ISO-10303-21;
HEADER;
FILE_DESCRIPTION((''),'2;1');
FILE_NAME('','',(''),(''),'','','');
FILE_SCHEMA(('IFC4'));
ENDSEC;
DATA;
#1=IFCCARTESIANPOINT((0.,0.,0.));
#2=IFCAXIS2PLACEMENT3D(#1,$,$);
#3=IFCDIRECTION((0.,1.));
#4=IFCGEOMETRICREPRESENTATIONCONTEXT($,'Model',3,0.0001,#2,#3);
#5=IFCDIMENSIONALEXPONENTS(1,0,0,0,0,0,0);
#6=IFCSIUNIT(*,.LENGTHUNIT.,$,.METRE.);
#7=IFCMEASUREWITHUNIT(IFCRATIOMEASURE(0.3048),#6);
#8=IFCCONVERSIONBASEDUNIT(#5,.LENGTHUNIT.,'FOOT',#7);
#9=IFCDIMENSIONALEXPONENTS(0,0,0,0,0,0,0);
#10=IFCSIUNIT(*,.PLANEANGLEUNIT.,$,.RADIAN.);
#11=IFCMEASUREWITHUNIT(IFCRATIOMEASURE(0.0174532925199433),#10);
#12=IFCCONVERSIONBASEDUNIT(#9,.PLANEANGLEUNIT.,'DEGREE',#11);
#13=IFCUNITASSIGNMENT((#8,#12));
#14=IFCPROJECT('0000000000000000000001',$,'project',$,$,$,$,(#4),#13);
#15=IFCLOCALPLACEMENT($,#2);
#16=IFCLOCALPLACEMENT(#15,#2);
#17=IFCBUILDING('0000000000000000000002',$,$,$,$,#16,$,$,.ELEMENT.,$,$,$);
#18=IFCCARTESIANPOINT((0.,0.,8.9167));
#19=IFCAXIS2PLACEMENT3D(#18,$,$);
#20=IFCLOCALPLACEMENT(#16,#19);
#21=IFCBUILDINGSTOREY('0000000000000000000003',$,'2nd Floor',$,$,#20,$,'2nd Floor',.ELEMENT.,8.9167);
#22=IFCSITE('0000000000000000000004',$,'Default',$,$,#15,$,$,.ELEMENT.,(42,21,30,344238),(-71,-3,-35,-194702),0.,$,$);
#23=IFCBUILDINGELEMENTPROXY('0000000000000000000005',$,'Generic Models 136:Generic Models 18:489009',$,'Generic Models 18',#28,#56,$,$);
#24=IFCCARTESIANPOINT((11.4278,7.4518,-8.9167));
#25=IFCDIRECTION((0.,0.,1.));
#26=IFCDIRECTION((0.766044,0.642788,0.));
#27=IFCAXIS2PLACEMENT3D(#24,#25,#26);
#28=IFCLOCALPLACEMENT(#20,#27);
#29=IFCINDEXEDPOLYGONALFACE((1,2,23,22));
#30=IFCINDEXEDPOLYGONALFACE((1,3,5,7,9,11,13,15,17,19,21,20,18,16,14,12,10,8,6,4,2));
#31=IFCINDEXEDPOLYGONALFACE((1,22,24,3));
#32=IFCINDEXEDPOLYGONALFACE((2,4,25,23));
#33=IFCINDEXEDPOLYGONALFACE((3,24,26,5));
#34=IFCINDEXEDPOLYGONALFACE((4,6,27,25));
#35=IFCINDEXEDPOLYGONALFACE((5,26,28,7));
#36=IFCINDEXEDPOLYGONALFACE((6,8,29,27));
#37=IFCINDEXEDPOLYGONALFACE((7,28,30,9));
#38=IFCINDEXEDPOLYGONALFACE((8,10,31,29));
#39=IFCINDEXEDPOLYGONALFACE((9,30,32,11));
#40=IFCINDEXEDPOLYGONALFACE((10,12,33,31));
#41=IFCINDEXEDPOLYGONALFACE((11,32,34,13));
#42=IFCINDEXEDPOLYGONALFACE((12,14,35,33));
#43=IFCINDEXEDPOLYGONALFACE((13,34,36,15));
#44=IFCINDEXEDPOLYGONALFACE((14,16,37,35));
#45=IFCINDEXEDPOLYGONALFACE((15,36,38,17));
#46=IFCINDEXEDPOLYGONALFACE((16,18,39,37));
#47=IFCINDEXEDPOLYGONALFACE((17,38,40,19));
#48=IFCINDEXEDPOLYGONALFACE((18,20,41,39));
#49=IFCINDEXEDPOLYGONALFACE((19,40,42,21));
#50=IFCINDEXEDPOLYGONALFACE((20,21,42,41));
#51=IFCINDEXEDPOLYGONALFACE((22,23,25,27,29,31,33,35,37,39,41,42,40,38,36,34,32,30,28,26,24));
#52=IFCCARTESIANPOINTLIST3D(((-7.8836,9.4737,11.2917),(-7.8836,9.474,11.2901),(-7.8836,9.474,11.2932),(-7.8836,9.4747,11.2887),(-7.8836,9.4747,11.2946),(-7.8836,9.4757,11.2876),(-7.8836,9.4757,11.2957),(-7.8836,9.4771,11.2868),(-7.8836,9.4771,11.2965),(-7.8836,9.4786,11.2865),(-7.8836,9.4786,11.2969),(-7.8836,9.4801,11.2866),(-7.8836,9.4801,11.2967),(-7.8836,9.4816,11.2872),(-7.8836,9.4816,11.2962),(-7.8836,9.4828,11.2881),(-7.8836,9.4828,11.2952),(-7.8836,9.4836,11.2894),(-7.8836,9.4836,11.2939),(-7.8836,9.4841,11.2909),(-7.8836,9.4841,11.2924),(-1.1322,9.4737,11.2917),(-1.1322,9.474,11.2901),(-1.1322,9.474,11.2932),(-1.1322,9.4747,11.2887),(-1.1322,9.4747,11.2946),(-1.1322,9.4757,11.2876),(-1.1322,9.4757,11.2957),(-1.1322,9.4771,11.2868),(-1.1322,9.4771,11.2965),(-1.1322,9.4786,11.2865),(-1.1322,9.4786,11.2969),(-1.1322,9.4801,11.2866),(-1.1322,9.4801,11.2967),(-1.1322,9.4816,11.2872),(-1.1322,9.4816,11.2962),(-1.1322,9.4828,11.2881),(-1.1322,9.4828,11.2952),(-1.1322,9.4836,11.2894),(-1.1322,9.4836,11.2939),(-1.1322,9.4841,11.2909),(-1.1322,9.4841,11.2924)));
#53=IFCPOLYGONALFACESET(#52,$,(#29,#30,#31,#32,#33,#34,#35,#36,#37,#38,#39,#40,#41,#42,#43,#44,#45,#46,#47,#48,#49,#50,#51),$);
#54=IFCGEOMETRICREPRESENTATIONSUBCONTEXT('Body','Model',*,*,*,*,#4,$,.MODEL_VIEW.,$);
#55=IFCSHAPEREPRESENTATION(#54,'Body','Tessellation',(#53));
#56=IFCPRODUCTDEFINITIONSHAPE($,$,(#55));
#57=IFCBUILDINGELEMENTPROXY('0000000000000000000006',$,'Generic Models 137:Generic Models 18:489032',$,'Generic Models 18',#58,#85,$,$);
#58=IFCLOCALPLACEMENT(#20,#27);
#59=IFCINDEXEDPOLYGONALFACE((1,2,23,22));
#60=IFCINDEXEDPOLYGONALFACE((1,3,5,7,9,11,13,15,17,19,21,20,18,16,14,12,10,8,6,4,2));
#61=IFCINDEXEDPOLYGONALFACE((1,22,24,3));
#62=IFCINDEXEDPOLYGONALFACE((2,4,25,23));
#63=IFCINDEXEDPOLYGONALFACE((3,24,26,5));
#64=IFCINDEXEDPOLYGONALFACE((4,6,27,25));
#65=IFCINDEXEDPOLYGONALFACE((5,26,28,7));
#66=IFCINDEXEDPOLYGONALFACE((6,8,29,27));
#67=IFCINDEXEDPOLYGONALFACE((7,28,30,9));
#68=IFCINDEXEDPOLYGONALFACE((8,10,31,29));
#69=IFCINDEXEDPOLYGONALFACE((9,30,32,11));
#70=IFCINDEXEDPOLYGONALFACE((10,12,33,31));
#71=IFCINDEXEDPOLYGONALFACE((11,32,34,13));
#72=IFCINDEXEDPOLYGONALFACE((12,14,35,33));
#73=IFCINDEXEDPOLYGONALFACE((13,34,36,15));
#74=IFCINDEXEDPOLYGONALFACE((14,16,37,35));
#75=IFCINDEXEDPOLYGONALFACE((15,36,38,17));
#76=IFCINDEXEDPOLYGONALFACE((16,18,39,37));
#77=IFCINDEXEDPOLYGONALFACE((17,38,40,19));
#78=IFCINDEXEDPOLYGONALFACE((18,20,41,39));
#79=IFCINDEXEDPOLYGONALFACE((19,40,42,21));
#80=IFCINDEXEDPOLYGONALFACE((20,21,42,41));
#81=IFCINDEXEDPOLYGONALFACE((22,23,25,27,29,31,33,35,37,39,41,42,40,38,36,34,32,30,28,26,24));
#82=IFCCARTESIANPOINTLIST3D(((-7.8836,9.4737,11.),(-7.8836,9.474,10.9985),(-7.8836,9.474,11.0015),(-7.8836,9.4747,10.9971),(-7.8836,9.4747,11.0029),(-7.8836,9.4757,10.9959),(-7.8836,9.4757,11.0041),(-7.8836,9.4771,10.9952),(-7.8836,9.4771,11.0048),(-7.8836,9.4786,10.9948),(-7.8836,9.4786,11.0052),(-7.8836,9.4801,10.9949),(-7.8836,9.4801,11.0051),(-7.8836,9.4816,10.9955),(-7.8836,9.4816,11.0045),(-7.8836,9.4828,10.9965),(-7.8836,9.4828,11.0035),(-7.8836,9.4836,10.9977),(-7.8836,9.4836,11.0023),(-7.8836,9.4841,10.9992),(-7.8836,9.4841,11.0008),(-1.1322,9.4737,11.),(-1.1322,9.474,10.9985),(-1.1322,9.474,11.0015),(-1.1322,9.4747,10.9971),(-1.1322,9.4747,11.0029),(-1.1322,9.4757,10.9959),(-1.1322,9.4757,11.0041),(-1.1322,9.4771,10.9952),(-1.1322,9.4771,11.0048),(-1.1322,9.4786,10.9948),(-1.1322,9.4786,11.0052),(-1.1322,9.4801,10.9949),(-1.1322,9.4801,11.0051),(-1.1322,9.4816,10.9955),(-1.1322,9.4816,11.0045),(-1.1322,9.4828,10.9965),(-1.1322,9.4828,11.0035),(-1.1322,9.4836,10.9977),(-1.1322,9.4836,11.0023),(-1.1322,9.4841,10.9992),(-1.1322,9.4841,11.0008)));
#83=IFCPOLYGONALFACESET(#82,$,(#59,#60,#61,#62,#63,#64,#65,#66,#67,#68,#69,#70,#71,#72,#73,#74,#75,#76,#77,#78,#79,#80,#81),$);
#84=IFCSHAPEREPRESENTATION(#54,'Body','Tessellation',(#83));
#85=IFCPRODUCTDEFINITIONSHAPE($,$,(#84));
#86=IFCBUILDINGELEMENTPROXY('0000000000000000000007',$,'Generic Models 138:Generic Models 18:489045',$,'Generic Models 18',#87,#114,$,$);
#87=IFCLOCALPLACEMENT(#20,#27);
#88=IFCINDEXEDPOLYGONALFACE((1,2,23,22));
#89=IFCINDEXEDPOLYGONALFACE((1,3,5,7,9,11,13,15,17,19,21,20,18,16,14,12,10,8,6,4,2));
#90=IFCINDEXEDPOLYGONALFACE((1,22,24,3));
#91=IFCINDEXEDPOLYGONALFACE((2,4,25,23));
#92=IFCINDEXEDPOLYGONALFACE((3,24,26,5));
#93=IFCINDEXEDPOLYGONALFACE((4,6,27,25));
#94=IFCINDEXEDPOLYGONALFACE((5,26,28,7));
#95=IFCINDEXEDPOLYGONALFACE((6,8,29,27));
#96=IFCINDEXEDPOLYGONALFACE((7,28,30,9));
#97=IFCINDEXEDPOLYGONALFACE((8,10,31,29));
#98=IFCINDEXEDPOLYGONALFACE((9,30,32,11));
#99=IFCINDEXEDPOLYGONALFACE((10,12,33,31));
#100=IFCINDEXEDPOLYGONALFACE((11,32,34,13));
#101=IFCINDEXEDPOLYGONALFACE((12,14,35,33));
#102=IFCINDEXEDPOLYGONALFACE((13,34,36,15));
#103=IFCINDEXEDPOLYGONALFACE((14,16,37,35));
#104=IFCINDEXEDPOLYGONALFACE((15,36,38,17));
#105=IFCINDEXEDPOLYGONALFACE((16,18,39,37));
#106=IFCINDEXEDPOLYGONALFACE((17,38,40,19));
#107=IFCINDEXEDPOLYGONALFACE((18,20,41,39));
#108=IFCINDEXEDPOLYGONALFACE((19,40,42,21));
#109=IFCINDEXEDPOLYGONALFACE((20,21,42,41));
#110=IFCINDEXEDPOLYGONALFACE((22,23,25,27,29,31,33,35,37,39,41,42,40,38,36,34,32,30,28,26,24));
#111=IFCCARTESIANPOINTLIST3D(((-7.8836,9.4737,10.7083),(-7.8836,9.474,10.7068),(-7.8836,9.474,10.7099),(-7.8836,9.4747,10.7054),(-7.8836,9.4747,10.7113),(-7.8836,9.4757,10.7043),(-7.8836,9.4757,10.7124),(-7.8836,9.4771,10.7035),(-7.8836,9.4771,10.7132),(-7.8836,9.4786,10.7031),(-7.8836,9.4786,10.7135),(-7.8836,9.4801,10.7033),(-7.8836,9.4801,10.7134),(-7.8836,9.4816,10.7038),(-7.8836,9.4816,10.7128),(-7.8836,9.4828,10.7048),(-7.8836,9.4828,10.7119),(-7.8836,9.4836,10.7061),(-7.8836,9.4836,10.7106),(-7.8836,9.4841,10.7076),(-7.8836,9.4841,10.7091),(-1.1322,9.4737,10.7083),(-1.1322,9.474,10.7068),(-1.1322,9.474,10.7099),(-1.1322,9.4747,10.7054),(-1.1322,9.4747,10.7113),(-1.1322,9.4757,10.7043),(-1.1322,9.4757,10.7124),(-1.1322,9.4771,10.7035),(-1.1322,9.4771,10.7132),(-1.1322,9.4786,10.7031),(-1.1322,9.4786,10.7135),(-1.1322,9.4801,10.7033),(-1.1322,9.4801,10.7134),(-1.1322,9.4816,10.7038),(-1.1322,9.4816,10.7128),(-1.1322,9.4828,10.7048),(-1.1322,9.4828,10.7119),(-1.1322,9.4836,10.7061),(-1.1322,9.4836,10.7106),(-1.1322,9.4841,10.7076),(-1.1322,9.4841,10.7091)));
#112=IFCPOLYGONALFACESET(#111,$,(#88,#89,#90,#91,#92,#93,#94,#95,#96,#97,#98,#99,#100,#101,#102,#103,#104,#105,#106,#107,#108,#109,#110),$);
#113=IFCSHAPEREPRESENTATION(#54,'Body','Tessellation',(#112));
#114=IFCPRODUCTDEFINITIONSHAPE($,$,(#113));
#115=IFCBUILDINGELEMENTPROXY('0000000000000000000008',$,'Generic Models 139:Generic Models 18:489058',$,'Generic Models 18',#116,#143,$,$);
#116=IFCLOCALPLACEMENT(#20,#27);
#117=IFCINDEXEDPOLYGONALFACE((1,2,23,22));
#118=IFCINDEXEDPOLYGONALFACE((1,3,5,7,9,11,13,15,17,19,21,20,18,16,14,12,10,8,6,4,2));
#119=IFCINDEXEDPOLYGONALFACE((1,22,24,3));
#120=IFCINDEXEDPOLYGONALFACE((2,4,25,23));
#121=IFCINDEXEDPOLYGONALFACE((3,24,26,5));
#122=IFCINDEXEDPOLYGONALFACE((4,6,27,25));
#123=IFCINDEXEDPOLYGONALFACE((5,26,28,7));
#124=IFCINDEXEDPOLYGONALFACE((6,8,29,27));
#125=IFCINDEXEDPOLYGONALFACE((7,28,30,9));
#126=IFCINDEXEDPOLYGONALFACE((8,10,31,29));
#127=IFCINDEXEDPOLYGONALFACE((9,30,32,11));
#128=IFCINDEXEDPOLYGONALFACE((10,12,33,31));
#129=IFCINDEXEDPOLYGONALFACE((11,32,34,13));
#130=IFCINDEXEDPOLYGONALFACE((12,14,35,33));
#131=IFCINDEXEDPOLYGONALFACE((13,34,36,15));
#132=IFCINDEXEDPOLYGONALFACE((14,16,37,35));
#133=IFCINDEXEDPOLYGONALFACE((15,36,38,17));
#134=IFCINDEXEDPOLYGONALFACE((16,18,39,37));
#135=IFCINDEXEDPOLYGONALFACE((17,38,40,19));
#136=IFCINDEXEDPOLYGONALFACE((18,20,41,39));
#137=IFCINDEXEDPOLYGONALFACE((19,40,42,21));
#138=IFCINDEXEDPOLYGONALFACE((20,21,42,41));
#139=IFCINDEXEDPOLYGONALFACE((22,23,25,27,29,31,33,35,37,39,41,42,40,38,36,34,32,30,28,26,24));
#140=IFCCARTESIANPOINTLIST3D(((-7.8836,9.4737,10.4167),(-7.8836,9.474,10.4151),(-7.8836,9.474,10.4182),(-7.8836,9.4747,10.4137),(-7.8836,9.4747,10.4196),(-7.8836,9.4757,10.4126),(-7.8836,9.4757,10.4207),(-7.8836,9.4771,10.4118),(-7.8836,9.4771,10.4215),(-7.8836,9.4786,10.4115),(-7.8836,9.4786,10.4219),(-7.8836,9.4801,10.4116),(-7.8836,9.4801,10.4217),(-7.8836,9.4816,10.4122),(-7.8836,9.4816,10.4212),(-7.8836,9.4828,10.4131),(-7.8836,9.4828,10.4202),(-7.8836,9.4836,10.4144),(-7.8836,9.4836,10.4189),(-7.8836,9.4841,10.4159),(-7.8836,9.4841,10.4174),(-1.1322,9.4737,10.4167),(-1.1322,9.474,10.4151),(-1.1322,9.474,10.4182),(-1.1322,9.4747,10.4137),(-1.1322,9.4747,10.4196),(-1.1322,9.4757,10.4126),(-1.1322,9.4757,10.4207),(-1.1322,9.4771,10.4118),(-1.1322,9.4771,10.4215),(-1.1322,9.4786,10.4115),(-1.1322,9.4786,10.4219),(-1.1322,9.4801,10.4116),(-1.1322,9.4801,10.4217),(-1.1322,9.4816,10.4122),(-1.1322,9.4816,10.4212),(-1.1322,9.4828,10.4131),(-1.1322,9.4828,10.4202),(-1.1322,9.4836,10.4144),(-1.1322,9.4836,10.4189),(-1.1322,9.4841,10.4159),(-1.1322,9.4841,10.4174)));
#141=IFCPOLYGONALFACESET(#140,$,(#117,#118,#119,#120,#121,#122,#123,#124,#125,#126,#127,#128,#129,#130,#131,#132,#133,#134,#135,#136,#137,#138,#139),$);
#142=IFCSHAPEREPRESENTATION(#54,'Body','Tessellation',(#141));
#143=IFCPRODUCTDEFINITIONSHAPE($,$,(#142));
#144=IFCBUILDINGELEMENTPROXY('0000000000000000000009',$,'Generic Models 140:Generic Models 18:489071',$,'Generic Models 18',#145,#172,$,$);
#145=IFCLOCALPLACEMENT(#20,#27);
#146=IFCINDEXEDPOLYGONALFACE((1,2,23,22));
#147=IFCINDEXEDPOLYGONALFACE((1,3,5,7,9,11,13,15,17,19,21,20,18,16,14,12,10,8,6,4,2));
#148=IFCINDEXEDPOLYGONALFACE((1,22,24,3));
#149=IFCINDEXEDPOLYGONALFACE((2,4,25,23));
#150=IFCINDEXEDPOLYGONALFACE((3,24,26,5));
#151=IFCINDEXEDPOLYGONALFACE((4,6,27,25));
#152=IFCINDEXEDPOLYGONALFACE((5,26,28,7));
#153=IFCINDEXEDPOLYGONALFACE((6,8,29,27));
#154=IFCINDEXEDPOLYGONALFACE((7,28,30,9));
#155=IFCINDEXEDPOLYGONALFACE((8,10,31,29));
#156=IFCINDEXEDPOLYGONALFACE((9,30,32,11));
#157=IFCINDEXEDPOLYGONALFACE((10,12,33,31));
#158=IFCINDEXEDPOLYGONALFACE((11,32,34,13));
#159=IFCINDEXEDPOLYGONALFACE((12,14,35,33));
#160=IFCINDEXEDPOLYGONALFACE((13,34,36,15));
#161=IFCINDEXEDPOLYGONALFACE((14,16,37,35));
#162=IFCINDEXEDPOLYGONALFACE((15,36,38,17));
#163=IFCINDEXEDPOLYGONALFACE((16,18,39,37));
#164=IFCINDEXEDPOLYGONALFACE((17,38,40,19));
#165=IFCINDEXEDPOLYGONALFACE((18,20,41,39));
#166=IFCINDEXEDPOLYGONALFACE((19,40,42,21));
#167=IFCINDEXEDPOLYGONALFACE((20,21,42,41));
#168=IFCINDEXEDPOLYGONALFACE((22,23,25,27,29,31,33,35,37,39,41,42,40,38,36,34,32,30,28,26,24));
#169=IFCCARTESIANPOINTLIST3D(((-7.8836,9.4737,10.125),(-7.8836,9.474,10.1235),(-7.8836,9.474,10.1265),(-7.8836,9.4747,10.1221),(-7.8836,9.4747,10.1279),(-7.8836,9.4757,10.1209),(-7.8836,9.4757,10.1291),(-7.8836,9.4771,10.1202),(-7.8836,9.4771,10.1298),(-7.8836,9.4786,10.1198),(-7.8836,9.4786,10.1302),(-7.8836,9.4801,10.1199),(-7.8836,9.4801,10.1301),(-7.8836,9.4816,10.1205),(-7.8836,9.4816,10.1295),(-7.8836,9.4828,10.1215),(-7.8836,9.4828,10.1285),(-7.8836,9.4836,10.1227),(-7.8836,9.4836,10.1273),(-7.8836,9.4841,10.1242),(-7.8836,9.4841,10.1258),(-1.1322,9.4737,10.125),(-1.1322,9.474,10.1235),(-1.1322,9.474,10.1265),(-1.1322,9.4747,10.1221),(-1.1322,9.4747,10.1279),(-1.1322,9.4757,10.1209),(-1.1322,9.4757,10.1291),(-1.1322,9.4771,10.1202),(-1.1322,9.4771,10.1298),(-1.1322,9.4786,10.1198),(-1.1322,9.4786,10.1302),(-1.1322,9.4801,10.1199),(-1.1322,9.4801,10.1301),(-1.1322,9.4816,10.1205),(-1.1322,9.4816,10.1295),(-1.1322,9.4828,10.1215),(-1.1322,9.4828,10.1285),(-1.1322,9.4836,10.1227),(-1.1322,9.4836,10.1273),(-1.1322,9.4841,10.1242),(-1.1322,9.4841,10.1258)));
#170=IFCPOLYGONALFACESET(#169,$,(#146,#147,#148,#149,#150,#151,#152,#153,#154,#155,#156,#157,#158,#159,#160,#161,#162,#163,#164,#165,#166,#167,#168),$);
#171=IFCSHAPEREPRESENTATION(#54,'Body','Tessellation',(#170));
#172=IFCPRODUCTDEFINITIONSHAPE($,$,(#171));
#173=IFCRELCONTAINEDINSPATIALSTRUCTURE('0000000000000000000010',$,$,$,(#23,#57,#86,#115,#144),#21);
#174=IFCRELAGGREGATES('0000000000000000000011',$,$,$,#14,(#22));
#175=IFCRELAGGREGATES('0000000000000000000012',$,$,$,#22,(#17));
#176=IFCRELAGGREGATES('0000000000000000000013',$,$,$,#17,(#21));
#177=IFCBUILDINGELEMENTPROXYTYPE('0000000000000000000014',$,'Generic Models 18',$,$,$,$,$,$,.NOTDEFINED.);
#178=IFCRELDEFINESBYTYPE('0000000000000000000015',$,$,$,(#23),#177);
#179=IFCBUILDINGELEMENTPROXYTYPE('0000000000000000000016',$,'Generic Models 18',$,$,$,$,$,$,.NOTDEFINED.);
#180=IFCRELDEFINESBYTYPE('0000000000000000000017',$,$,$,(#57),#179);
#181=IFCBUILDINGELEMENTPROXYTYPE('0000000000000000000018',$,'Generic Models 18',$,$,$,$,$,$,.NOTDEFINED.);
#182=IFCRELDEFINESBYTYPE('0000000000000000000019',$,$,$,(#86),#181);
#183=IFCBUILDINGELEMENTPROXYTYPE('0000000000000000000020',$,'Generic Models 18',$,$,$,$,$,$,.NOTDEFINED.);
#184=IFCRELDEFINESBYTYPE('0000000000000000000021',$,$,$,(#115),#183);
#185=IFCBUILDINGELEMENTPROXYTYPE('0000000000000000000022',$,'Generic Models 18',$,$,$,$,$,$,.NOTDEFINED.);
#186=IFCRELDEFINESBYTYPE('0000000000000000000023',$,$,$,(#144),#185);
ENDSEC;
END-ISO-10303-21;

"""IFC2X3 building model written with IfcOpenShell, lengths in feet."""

from ifc_helpers import new_model, entity, si_unit, converted_unit, direction, frame, origin, origin_2d_with_axis, place, context, subcontext, project, spatial, circle, extrude, source, transform, mapped, type_object, type_shapes, element, save


model = new_model("IFC2X3")

# Units and contexts
model_context = context("Model", 3, precision=0.0001, world=origin(), true_north=direction((0.0, 1.0)))
body_context = subcontext(model_context, "Body", "Model", "MODEL_VIEW")
ifc_project = project(units=[converted_unit("LENGTHUNIT", "FOOT", entity("IfcRatioMeasure", 0.3048), si_unit("LENGTHUNIT", "METRE"), dimensions=[1, 0, 0, 0, 0, 0, 0]), converted_unit("PLANEANGLEUNIT", "DEGREE", entity("IfcRatioMeasure", 0.0174532925199433), si_unit("PLANEANGLEUNIT", "RADIAN"), dimensions=[0, 0, 0, 0, 0, 0, 0])], contexts=[model_context])

# Site, building, storey
site_placement = place(None, origin())
site = spatial("IfcSite", under=ifc_project, at=site_placement, Name="Default", CompositionType="ELEMENT", RefLatitude=(42, 21, 30, 344238), RefLongitude=(-71, -3, -35, -194702), RefElevation=0.0)
building_placement = place(site_placement, origin())
building = spatial("IfcBuilding", under=site, at=building_placement, CompositionType="ELEMENT")
storey_placement = place(building_placement, frame((0.0, 0.0, 8.9167)))
storey = spatial("IfcBuildingStorey", under=building, at=storey_placement, Name="2nd Floor", LongName="2nd Floor", CompositionType="ELEMENT", Elevation=8.9167)

# Building element proxies
building_element_proxy_type_1 = type_object("IfcBuildingElementProxyType", Name="Generic Models 18", PredefinedType="NOTDEFINED")
shared_shape_1 = source(origin(), body_context, "Body", "SweptSolid", [
    extrude(circle(Radius=0.0052, at=origin_2d_with_axis()), frame((-7.8836, 9.479, 11.2917), z_axis=(1.0, 0.0, 0.0), x_axis=(0.0, -1.0, 0.0)), (0.0, 0.0, 1.0), 6.7514),
])
type_shapes(building_element_proxy_type_1, [shared_shape_1])
proxy_1_placement = place(storey_placement, frame((11.4278, 7.4518, -8.9167), z_axis=(0.0, 0.0, 1.0), x_axis=(0.766044, 0.642788, 0.0)))
element("IfcBuildingElementProxy", 1, at=proxy_1_placement, inside=storey, type_object=building_element_proxy_type_1, Name="Generic Models 136:Generic Models 18:489009", ObjectType="Generic Models 18", context=body_context, shape_type="MappedRepresentation", body=[
    mapped(shared_shape_1, transform((0.0, 0.0, 0.0), scale=1.0)),
])
building_element_proxy_type_2 = type_object("IfcBuildingElementProxyType", Name="Generic Models 18", PredefinedType="NOTDEFINED")
shared_shape_2 = source(origin(), body_context, "Body", "SweptSolid", [
    extrude(circle(Radius=0.0052, at=origin_2d_with_axis()), frame((-7.8836, 9.479, 11.0), z_axis=(1.0, 0.0, 0.0), x_axis=(0.0, -1.0, 0.0)), (0.0, 0.0, 1.0), 6.7514),
])
type_shapes(building_element_proxy_type_2, [shared_shape_2])
proxy_2_placement = place(storey_placement, frame((11.4278, 7.4518, -8.9167), z_axis=(0.0, 0.0, 1.0), x_axis=(0.766044, 0.642788, 0.0)))
element("IfcBuildingElementProxy", 2, at=proxy_2_placement, inside=storey, type_object=building_element_proxy_type_2, Name="Generic Models 137:Generic Models 18:489032", ObjectType="Generic Models 18", context=body_context, shape_type="MappedRepresentation", body=[
    mapped(shared_shape_2, transform((0.0, 0.0, 0.0), scale=1.0)),
])
building_element_proxy_type_3 = type_object("IfcBuildingElementProxyType", Name="Generic Models 18", PredefinedType="NOTDEFINED")
shared_shape_3 = source(origin(), body_context, "Body", "SweptSolid", [
    extrude(circle(Radius=0.0052, at=origin_2d_with_axis()), frame((-7.8836, 9.479, 10.7083), z_axis=(1.0, 0.0, 0.0), x_axis=(0.0, -1.0, 0.0)), (0.0, 0.0, 1.0), 6.7514),
])
type_shapes(building_element_proxy_type_3, [shared_shape_3])
proxy_3_placement = place(storey_placement, frame((11.4278, 7.4518, -8.9167), z_axis=(0.0, 0.0, 1.0), x_axis=(0.766044, 0.642788, 0.0)))
element("IfcBuildingElementProxy", 3, at=proxy_3_placement, inside=storey, type_object=building_element_proxy_type_3, Name="Generic Models 138:Generic Models 18:489045", ObjectType="Generic Models 18", context=body_context, shape_type="MappedRepresentation", body=[
    mapped(shared_shape_3, transform((0.0, 0.0, 0.0), scale=1.0)),
])
building_element_proxy_type_4 = type_object("IfcBuildingElementProxyType", Name="Generic Models 18", PredefinedType="NOTDEFINED")
shared_shape_4 = source(origin(), body_context, "Body", "SweptSolid", [
    extrude(circle(Radius=0.0052, at=origin_2d_with_axis()), frame((-7.8836, 9.479, 10.4167), z_axis=(1.0, 0.0, 0.0), x_axis=(0.0, -1.0, 0.0)), (0.0, 0.0, 1.0), 6.7514),
])
type_shapes(building_element_proxy_type_4, [shared_shape_4])
proxy_4_placement = place(storey_placement, frame((11.4278, 7.4518, -8.9167), z_axis=(0.0, 0.0, 1.0), x_axis=(0.766044, 0.642788, 0.0)))
element("IfcBuildingElementProxy", 4, at=proxy_4_placement, inside=storey, type_object=building_element_proxy_type_4, Name="Generic Models 139:Generic Models 18:489058", ObjectType="Generic Models 18", context=body_context, shape_type="MappedRepresentation", body=[
    mapped(shared_shape_4, transform((0.0, 0.0, 0.0), scale=1.0)),
])
building_element_proxy_type_5 = type_object("IfcBuildingElementProxyType", Name="Generic Models 18", PredefinedType="NOTDEFINED")
shared_shape_5 = source(origin(), body_context, "Body", "SweptSolid", [
    extrude(circle(Radius=0.0052, at=origin_2d_with_axis()), frame((-7.8836, 9.479, 10.125), z_axis=(1.0, 0.0, 0.0), x_axis=(0.0, -1.0, 0.0)), (0.0, 0.0, 1.0), 6.7514),
])
type_shapes(building_element_proxy_type_5, [shared_shape_5])
proxy_5_placement = place(storey_placement, frame((11.4278, 7.4518, -8.9167), z_axis=(0.0, 0.0, 1.0), x_axis=(0.766044, 0.642788, 0.0)))
element("IfcBuildingElementProxy", 5, at=proxy_5_placement, inside=storey, type_object=building_element_proxy_type_5, Name="Generic Models 140:Generic Models 18:489071", ObjectType="Generic Models 18", context=body_context, shape_type="MappedRepresentation", body=[
    mapped(shared_shape_5, transform((0.0, 0.0, 0.0), scale=1.0)),
])

save(model, "model.ifc")
